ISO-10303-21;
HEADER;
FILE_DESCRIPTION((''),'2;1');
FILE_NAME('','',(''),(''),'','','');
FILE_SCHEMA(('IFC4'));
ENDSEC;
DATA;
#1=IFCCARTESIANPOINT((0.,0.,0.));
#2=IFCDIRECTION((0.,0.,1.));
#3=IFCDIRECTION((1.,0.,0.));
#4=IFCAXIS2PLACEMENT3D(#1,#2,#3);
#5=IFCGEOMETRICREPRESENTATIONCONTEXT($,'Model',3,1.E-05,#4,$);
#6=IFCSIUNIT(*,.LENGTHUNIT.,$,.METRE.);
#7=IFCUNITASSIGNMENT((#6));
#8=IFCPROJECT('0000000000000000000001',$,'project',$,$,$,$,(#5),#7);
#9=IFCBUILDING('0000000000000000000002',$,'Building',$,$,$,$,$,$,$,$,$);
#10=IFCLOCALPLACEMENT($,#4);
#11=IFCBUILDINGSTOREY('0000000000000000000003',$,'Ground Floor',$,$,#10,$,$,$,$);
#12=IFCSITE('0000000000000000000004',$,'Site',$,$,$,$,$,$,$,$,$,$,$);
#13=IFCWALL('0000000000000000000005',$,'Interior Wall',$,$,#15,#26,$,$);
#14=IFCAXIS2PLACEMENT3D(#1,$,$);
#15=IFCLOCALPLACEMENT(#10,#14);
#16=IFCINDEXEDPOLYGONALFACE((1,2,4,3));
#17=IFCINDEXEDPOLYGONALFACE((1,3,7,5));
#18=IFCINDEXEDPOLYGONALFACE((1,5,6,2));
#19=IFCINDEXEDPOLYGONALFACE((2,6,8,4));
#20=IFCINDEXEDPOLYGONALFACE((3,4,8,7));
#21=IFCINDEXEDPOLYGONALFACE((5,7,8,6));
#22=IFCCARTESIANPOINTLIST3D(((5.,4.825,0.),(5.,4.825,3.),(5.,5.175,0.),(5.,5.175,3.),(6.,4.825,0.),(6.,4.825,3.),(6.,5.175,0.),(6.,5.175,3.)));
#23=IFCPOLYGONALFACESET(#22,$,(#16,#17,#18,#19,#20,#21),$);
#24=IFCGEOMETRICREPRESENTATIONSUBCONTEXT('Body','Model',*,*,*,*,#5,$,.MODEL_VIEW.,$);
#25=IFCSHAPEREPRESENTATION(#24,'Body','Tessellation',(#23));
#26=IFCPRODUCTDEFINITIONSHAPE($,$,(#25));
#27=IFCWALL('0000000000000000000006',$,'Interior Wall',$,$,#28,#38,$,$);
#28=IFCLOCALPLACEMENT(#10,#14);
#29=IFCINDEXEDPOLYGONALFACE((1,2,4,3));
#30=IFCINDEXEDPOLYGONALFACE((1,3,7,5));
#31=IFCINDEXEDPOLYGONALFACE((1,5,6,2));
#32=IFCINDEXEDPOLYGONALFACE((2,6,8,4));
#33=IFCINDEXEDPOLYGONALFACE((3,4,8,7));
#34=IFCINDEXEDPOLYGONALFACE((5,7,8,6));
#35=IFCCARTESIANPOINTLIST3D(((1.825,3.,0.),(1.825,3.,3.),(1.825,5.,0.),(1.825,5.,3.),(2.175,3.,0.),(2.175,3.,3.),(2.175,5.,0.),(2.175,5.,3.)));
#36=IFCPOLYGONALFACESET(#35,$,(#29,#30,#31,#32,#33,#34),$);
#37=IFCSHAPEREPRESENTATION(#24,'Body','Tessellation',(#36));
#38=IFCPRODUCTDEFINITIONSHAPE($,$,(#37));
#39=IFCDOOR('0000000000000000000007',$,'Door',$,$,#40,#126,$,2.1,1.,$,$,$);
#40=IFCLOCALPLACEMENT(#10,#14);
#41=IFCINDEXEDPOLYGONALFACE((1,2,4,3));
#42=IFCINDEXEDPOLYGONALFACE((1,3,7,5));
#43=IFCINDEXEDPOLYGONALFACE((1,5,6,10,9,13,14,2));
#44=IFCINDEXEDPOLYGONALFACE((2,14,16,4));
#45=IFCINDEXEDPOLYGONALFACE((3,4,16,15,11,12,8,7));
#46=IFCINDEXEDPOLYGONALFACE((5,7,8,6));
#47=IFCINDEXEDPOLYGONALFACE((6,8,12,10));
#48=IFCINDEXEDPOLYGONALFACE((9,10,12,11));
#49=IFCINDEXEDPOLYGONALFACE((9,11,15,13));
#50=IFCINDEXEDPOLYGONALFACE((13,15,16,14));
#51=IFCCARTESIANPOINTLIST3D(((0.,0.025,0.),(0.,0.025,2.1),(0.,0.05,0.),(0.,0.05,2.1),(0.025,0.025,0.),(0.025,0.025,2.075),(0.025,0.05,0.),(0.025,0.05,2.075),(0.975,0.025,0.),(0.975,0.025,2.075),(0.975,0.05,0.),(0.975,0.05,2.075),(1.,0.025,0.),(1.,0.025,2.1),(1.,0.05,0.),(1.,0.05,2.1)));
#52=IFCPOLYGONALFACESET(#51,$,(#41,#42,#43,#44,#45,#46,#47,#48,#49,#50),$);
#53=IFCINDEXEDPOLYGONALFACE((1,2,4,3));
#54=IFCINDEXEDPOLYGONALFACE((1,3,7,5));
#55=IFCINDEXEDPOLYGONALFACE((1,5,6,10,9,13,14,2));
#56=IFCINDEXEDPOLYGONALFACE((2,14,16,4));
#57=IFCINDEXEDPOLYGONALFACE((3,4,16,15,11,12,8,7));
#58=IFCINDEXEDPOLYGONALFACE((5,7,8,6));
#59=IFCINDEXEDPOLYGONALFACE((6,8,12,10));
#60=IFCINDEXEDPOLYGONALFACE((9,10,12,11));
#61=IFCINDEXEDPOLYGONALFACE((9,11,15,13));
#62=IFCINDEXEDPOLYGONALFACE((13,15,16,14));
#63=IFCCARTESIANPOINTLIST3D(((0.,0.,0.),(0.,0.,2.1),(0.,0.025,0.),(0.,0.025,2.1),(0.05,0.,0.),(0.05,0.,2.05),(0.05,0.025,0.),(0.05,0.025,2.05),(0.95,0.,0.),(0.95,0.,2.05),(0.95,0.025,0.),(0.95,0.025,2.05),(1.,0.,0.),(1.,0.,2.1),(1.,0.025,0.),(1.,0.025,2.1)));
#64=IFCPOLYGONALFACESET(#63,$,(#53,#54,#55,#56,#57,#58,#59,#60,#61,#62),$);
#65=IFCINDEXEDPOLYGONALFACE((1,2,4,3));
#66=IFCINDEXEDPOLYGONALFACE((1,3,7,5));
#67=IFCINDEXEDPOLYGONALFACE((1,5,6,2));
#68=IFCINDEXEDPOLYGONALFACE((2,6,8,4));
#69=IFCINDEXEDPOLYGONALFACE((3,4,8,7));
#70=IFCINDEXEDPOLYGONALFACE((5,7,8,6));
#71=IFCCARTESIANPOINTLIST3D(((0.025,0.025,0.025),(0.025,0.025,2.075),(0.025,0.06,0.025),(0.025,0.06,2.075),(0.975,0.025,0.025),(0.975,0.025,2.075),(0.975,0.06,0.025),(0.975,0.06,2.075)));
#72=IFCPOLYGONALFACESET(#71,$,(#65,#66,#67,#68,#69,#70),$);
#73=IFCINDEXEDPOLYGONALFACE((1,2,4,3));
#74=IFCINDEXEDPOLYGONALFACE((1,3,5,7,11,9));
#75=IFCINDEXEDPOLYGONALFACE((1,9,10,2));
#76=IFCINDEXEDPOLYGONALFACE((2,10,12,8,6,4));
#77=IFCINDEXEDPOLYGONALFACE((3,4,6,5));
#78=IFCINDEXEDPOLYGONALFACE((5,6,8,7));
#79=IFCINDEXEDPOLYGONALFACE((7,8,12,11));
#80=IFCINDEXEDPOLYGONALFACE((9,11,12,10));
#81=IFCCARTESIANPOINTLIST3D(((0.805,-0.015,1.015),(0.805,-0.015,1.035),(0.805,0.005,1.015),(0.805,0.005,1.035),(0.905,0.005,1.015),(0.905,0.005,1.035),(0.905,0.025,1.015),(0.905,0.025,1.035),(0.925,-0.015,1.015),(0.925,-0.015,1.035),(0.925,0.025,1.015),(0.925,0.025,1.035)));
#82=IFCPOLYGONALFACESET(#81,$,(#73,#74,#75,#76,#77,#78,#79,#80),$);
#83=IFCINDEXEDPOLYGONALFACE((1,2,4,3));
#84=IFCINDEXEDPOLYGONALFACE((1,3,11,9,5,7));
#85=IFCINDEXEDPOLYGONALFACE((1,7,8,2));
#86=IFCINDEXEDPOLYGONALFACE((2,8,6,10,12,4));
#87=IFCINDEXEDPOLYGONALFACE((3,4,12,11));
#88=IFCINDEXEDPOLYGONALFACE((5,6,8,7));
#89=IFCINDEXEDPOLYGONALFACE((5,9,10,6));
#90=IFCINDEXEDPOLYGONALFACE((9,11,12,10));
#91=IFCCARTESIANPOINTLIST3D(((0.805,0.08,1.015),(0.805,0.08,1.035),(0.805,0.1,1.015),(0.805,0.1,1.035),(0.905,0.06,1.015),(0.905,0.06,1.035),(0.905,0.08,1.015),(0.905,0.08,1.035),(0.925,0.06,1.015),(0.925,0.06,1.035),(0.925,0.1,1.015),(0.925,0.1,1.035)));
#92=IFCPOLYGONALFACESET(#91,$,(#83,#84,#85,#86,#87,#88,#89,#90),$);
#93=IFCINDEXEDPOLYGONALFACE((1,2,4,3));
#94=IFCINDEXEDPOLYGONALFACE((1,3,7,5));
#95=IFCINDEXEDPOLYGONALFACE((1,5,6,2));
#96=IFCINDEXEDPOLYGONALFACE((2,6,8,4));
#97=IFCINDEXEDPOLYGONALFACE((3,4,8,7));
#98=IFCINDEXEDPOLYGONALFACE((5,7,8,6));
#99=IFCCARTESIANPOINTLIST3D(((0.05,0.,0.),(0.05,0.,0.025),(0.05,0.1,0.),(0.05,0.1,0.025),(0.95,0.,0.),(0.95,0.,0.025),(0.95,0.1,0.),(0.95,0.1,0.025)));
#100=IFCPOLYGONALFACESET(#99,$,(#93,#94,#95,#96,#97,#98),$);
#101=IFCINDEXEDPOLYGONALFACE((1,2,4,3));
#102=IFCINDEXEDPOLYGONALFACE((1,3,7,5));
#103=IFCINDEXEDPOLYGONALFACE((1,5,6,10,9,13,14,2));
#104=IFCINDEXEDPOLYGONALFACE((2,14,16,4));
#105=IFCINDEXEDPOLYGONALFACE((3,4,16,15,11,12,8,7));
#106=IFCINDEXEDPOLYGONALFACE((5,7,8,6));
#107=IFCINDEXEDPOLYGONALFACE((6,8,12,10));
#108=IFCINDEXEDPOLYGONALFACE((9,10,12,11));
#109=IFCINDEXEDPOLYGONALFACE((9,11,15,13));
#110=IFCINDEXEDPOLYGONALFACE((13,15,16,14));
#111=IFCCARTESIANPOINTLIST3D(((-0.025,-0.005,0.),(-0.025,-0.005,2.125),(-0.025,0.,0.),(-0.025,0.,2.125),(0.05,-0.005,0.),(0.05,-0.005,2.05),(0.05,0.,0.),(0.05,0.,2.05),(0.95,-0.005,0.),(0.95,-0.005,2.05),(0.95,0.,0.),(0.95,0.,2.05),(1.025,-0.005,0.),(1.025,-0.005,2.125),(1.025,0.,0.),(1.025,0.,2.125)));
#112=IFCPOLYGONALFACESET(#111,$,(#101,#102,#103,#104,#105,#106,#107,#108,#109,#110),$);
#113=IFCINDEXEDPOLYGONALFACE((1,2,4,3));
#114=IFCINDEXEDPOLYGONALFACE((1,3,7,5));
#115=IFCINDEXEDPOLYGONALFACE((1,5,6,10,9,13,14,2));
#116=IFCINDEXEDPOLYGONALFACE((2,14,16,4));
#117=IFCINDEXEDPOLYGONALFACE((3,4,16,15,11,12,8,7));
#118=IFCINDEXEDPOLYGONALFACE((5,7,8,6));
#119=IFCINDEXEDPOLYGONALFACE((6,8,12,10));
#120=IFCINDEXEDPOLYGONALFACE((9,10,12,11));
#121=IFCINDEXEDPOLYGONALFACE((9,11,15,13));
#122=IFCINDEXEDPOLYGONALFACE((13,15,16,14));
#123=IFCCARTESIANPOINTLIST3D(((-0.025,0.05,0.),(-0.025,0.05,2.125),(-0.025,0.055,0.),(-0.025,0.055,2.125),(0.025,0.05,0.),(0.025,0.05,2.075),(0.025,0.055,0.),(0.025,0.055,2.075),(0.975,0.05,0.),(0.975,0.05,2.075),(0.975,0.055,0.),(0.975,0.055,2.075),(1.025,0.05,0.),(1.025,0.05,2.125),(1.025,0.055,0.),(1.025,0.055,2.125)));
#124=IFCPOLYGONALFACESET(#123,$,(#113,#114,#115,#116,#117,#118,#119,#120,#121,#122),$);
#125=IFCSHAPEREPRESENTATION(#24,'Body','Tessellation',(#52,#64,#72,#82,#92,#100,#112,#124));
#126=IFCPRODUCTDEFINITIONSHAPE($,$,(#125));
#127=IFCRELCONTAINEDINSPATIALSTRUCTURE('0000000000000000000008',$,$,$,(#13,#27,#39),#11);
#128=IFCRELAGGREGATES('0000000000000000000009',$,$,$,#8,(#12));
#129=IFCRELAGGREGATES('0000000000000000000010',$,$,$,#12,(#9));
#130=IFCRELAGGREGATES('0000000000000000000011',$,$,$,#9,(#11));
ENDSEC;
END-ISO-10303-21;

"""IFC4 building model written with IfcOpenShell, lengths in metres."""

from ifc_helpers import new_model, si_unit, frame, origin_with_axes, place, context, subcontext, project, spatial, line, indexed_curve, outline, extrude, element, save


model = new_model("IFC4")

# Units and contexts
model_context = context("Model", 3, precision=1e-05, world=origin_with_axes())
body_context = subcontext(model_context, "Body", "Model", "MODEL_VIEW")
ifc_project = project(units=[si_unit("LENGTHUNIT", "METRE")], contexts=[model_context])

# Site, building, storey
site = spatial("IfcSite", under=ifc_project, Name="Site")
building = spatial("IfcBuilding", under=site, Name="Building")
storey_placement = place(None, origin_with_axes())
storey = spatial("IfcBuildingStorey", under=building, at=storey_placement, Name="Ground Floor")

# Walls
wall_1_placement = place(storey_placement, frame((6.0, 5.0, 0.0), z_axis=(0.0, 0.0, 1.0), x_axis=(-1.0, 0.0, 0.0)))
element("IfcWall", 1, at=wall_1_placement, inside=storey, Name="Interior Wall", context=body_context, shape_type="SweptSolid", body=[
    extrude(outline(indexed_curve([(0.0, 0.0), (0.0, 0.35), (1.0, 0.35), (1.0, 0.0), (0.0, 0.0)], self_intersect=False)), frame((0.0, -0.175, 0.0), z_axis=(0.0, 0.0, 1.0), x_axis=(1.0, 0.0, 0.0)), (0.0, 0.0, 1.0), 3.0),
])
wall_2_placement = place(storey_placement, frame((2.0, 5.0, 0.0), z_axis=(0.0, 0.0, 1.0), x_axis=(0.0, -1.0, 0.0)))
element("IfcWall", 2, at=wall_2_placement, inside=storey, Name="Interior Wall", context=body_context, shape_type="SweptSolid", body=[
    extrude(outline(indexed_curve([(0.0, 0.0), (0.0, 0.35), (2.0, 0.35), (2.0, 0.0), (0.0, 0.0)], self_intersect=False)), frame((0.0, -0.175, 0.0), z_axis=(0.0, 0.0, 1.0), x_axis=(1.0, 0.0, 0.0)), (0.0, 0.0, 1.0), 3.0),
])

# Door
door_1_placement = place(storey_placement, origin_with_axes())
element("IfcDoor", 3, at=door_1_placement, inside=storey, Name="Door", OverallHeight=2.1, OverallWidth=1.0, context=body_context, shape_type="SweptSolid", body=[
    extrude(outline(indexed_curve([(0.0, 0.0), (0.0, 2.1), (1.0, 2.1), (1.0, 0.0), (0.975, 0.0), (0.975, 2.075), (0.025, 2.075), (0.025, 0.0)], segments=[line(1, 2, 3, 4, 5, 6, 7, 8, 1)])), frame((0.0, 0.025, 0.0), z_axis=(0.0, -1.0, 0.0), x_axis=(1.0, 0.0, 0.0)), (0.0, 0.0, -1.0), 0.025),
    extrude(outline(indexed_curve([(0.0, 0.0), (0.0, 2.1), (1.0, 2.1), (1.0, 0.0), (0.95, 0.0), (0.95, 2.05), (0.05, 2.05), (0.05, 0.0)], segments=[line(1, 2, 3, 4, 5, 6, 7, 8, 1)])), frame((0.0, 0.0, 0.0), z_axis=(0.0, -1.0, 0.0), x_axis=(1.0, 0.0, 0.0)), (0.0, 0.0, -1.0), 0.025),
    extrude(outline(indexed_curve([(0.0, 0.0), (0.95, 0.0), (0.95, 0.035), (0.0, 0.035)], segments=[line(1, 2, 3, 4, 1)])), frame((0.025, 0.025, 0.025), z_axis=(0.0, 0.0, 1.0), x_axis=(1.0, 0.0, 0.0)), (0.0, 0.0, 1.0), 2.05),
    extrude(outline(indexed_curve([(0.0, 0.0), (0.0, -0.04), (-0.12, -0.04), (-0.12, -0.02), (-0.02, -0.02), (-0.02, 0.0)], segments=[line(1, 2, 3, 4, 5, 6, 1)])), frame((0.925, 0.025, 1.015), z_axis=(0.0, 0.0, 1.0), x_axis=(1.0, 0.0, 0.0)), (0.0, 0.0, 1.0), 0.02),
    extrude(outline(indexed_curve([(0.0, 0.0), (0.0, 0.04), (-0.12, 0.04), (-0.12, 0.02), (-0.02, 0.02), (-0.02, 0.0)], segments=[line(1, 2, 3, 4, 5, 6, 1)])), frame((0.925, 0.06, 1.015), z_axis=(0.0, 0.0, 1.0), x_axis=(1.0, 0.0, 0.0)), (0.0, 0.0, 1.0), 0.02),
    extrude(outline(indexed_curve([(0.0, 0.0), (0.9, 0.0), (0.9, 0.1), (0.0, 0.1)], segments=[line(1, 2, 3, 4, 1)])), frame((0.05, 0.0, 0.0), z_axis=(0.0, 0.0, 1.0), x_axis=(1.0, 0.0, 0.0)), (0.0, 0.0, 1.0), 0.025),
    extrude(outline(indexed_curve([(0.0, 0.0), (0.0, 2.125), (1.05, 2.125), (1.05, 0.0), (0.975, 0.0), (0.975, 2.05), (0.075, 2.05), (0.075, 0.0)], segments=[line(1, 2, 3, 4, 5, 6, 7, 8, 1)])), frame((-0.025, -0.005, 0.0), z_axis=(0.0, -1.0, 0.0), x_axis=(1.0, 0.0, 0.0)), (0.0, 0.0, -1.0), 0.005),
    extrude(outline(indexed_curve([(0.0, 0.0), (0.0, 2.125), (1.05, 2.125), (1.05, 0.0), (1.0, 0.0), (1.0, 2.075), (0.05, 2.075), (0.05, 0.0)], segments=[line(1, 2, 3, 4, 5, 6, 7, 8, 1)])), frame((-0.025, 0.05, 0.0), z_axis=(0.0, -1.0, 0.0), x_axis=(1.0, 0.0, 0.0)), (0.0, 0.0, -1.0), 0.005),
])

save(model, "model.ifc")
